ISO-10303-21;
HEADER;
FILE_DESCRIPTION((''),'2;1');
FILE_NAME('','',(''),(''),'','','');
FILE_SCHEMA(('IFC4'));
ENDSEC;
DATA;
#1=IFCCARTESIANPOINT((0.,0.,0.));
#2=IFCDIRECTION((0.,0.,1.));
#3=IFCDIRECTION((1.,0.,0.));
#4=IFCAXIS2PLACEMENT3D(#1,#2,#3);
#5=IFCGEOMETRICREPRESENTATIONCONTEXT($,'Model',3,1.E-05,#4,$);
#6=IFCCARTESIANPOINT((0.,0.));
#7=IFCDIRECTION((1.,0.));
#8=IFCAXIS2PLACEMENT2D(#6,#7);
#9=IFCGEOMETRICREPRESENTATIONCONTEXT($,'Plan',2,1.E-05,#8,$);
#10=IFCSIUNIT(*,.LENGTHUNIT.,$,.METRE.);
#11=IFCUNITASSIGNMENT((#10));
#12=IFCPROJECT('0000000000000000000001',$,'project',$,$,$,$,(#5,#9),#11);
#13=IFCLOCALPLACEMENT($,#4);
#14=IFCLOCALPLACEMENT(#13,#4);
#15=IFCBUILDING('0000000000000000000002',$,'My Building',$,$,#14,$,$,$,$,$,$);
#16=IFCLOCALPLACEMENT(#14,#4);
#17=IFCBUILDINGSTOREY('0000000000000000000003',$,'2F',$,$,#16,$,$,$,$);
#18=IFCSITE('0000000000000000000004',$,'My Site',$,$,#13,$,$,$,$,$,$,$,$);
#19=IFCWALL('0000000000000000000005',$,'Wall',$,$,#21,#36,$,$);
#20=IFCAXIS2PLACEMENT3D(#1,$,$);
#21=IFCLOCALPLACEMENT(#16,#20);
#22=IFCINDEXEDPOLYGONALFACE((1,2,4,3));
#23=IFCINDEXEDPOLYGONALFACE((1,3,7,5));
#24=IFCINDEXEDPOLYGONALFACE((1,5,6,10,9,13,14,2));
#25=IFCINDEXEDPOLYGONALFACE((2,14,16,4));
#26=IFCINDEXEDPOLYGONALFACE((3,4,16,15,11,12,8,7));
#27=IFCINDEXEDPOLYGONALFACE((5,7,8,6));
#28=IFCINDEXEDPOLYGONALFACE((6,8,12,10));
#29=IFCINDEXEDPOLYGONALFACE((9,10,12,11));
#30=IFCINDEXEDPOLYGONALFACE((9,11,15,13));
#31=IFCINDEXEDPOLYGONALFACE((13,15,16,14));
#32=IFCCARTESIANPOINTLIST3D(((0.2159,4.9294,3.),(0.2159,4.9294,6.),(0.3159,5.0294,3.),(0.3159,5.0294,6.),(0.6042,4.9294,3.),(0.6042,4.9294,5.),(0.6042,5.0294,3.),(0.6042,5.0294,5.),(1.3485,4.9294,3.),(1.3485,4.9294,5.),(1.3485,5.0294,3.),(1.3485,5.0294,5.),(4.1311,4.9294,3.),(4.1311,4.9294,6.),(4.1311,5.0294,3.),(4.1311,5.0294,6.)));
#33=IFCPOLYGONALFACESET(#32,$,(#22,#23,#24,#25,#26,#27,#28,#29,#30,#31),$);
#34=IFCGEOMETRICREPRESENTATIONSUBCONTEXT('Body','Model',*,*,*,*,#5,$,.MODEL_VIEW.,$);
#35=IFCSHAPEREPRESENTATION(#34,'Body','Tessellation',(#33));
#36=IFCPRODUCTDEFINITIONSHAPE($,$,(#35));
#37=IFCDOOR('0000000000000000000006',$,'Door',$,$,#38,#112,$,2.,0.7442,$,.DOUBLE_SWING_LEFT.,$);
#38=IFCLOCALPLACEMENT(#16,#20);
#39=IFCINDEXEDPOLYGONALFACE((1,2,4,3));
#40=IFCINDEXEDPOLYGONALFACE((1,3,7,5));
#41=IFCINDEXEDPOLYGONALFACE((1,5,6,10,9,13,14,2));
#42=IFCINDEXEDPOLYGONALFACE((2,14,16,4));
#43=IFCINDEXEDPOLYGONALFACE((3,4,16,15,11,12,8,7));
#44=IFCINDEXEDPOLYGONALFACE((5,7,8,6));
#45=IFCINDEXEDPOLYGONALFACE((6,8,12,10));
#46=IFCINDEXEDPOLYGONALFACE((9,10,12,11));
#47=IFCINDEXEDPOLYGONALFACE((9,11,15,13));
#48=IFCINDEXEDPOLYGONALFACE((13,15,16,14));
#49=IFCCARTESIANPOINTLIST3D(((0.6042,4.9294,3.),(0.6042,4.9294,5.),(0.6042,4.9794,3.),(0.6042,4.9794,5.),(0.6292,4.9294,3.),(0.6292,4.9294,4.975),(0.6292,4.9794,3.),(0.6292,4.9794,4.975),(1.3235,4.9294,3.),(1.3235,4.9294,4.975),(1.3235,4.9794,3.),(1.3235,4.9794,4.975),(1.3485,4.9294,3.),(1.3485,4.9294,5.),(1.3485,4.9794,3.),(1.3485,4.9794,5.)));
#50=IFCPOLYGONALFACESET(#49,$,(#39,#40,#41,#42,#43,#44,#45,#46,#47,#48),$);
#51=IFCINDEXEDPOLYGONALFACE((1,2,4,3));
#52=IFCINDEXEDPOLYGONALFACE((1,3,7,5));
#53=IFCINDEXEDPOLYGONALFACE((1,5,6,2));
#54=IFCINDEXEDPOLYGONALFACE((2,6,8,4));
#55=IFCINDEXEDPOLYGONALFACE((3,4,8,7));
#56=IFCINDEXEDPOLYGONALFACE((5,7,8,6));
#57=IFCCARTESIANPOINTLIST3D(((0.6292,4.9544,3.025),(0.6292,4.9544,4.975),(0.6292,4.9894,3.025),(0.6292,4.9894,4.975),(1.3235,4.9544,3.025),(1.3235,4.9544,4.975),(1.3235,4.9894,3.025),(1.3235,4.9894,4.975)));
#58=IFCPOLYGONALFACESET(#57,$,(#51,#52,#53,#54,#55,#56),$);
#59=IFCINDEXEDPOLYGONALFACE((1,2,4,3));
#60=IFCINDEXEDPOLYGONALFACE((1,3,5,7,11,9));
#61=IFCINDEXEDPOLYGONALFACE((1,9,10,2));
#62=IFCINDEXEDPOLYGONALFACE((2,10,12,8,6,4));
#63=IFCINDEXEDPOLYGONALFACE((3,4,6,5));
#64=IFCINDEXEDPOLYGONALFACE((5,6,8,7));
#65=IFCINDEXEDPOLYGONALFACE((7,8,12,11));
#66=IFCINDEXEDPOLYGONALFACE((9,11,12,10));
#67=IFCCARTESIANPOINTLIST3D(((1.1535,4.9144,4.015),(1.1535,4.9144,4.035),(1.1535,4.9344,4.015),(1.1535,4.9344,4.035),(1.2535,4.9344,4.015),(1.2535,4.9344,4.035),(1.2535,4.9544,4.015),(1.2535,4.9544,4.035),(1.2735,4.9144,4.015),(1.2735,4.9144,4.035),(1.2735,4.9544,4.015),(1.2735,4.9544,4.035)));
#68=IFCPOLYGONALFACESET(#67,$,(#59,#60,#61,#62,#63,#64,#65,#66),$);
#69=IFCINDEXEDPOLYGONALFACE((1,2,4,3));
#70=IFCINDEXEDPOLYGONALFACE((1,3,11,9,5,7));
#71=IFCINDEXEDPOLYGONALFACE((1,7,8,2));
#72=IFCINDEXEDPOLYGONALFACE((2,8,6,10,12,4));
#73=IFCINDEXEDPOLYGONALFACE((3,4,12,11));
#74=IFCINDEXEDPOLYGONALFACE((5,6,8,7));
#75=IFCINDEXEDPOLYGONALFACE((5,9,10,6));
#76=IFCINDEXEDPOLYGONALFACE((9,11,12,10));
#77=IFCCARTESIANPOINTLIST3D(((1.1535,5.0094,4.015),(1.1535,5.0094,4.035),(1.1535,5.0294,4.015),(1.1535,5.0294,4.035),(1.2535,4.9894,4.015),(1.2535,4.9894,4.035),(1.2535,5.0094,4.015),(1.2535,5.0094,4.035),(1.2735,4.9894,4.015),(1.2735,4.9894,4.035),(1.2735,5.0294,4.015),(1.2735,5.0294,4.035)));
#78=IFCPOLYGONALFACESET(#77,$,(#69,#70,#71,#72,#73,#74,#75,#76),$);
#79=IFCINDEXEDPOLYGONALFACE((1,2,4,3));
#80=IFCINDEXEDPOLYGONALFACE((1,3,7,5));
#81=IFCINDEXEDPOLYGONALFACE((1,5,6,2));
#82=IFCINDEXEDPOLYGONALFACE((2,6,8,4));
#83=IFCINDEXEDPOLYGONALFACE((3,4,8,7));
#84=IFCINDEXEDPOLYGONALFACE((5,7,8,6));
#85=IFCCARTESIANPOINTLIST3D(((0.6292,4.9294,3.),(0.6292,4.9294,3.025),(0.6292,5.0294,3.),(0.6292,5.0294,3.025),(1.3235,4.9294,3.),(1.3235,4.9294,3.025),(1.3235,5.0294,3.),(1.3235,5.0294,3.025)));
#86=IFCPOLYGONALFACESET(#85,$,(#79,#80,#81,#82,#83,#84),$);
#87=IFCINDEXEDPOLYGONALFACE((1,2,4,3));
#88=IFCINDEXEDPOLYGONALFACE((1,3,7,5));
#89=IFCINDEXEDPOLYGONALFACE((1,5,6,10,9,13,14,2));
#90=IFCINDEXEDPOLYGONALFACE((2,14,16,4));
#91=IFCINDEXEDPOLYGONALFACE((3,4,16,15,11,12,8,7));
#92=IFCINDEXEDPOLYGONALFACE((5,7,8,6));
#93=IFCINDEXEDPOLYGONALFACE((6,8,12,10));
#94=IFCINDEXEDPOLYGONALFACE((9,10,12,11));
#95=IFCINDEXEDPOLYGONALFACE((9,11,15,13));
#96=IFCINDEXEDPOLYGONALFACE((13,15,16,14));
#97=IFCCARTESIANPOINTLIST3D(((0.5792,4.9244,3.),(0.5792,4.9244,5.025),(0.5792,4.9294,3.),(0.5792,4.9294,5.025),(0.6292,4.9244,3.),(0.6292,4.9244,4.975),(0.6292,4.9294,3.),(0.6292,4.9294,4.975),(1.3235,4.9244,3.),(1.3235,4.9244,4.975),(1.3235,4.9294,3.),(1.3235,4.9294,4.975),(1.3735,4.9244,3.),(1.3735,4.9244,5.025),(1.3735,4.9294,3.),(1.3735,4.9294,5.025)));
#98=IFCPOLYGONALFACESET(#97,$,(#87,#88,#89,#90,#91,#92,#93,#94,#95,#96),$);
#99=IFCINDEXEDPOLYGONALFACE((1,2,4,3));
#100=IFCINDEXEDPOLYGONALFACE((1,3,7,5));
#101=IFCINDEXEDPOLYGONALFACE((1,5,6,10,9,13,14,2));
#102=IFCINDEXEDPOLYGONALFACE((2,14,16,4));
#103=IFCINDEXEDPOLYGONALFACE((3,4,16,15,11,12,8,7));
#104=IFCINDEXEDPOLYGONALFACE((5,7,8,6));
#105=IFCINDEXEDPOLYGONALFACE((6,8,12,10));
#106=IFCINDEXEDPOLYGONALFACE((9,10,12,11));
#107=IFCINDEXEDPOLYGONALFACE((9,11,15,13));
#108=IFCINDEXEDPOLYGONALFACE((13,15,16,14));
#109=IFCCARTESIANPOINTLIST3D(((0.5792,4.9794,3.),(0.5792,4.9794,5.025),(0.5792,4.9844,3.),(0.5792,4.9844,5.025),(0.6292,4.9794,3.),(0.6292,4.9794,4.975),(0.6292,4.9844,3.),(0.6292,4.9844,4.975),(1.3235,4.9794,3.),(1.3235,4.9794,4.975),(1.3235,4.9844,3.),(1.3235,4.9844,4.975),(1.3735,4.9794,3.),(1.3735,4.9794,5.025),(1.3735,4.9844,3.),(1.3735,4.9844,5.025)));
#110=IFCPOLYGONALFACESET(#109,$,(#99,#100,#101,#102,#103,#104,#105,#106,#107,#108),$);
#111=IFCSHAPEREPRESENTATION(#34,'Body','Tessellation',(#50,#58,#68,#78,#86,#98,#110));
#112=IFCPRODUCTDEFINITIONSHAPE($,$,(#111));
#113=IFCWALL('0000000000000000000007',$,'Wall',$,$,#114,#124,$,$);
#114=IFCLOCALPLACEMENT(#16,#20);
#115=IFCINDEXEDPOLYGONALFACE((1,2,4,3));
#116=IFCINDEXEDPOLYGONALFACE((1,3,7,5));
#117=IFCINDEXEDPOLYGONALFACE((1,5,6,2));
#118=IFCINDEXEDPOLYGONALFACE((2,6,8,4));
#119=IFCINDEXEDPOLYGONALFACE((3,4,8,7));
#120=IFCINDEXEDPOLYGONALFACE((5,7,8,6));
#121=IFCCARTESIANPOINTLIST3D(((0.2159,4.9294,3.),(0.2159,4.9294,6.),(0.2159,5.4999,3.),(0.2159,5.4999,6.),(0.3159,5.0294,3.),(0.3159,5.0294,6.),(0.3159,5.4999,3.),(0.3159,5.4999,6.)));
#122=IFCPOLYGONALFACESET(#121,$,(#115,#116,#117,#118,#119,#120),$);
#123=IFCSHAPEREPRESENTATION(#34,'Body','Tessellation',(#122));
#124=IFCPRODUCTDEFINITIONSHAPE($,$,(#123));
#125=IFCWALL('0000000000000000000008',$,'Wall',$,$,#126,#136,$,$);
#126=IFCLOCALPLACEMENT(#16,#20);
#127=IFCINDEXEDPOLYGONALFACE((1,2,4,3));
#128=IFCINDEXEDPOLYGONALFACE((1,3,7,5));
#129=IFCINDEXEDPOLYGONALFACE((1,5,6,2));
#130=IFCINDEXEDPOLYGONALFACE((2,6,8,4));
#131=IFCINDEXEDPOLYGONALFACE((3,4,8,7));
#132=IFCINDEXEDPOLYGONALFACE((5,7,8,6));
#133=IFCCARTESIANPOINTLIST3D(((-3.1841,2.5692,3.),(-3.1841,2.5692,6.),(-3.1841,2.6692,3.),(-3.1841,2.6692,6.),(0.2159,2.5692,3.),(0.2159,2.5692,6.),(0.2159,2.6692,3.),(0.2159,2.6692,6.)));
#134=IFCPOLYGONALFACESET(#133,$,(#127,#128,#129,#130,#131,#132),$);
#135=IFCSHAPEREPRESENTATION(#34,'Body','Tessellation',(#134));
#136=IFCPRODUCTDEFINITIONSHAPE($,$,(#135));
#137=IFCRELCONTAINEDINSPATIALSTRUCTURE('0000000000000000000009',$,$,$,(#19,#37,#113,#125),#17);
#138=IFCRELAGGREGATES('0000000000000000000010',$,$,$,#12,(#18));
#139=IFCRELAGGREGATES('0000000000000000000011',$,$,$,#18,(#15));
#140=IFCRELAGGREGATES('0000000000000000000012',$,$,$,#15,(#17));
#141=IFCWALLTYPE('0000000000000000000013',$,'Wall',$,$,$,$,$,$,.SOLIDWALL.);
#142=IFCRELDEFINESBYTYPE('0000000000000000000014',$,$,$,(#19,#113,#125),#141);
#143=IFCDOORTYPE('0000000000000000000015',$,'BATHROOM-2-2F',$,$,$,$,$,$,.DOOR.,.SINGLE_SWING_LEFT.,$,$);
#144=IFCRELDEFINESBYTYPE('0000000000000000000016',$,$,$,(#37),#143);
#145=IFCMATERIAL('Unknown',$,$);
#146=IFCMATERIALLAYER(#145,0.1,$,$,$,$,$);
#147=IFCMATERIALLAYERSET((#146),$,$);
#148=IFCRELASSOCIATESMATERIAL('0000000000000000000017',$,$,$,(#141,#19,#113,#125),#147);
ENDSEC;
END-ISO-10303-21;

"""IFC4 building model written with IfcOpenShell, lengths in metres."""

from ifc_helpers import new_model, entity, si_unit, frame, origin_with_axes, origin_2d_with_axis, place, context, subcontext, project, spatial, line, indexed_curve, outline, extrude, shape, source, transform, mapped, material, layer, layer_set, layer_usage, type_object, type_shapes, element, fill, save


model = new_model("IFC4")

# Units and contexts
model_context = context("Model", 3, precision=1e-05, world=origin_with_axes())
plan_context = context("Plan", 2, precision=1e-05, world=origin_2d_with_axis())
body_context_1 = subcontext(model_context, "Body", "Model", "MODEL_VIEW")
body_context_2 = subcontext(plan_context, "Body", "Plan", "PLAN_VIEW")
ifc_project = project(units=[si_unit("LENGTHUNIT", "METRE")], contexts=[model_context, plan_context])

# Site, building, storey
site_placement = place(None, origin_with_axes())
site = spatial("IfcSite", under=ifc_project, at=site_placement, Name="My Site")
building_placement = place(site_placement, origin_with_axes())
building = spatial("IfcBuilding", under=site, at=building_placement, Name="My Building")
storey_placement = place(building_placement, origin_with_axes())
storey = spatial("IfcBuildingStorey", under=building, at=storey_placement, Name="2F")

# Shared definitions
ifc_material_1 = material(Name="Unknown")

# Shared definitions
ifc_layer_1 = layer(ifc_material_1, 0.1)
ifc_layer_set_1 = layer_set([ifc_layer_1])
wall_type = type_object("IfcWallType", Name="Wall", PredefinedType="SOLIDWALL", material=ifc_layer_set_1)

# Wall, opening, door
ifc_layer_usage_1 = layer_usage(ifc_layer_set_1, "AXIS2", "POSITIVE", 0.0)
wall_1_placement = place(storey_placement, frame((4.1311, 5.0294, 3.0), z_axis=(0.0, 0.0, 1.0), x_axis=(-1.0, 0.0, 0.0)))
wall_1 = element("IfcWall", 1, at=wall_1_placement, inside=storey, type_object=wall_type, material=ifc_layer_usage_1, Name="Wall", context=body_context_1, shape_type="SweptSolid", body=[
    extrude(outline(indexed_curve([(0.0, 0.0), (0.0, 0.1), (3.9153, 0.1), (3.8153, 0.0)], segments=[line(1, 2, 3, 4, 1)])), origin_with_axes(), (0.0, 0.0, 1.0), 3.0),
])
shared_shape_1 = source(origin_with_axes(), body_context_1, "Body", "SweptSolid", [
    extrude(outline(indexed_curve([(0.0, 0.0), (0.7442, 0.0), (0.7442, 2.0), (0.0, 2.0)], segments=[line(1, 2, 3, 4, 1)])), frame((0.0, -0.6, 0.0), z_axis=(0.0, -1.0, 0.0), x_axis=(1.0, 0.0, 0.0)), (0.0, 0.0, -1.0), 1.2),
])
opening_1_placement = place(wall_1_placement, frame((3.5269, 0.1, 0.0), z_axis=(0.0, 0.0, 1.0), x_axis=(-1.0, 0.0, 0.0)))
opening_1 = element("IfcOpeningElement", 2, at=opening_1_placement, cuts=wall_1, PredefinedType="OPENING", context=body_context_1, shape_type="MappedRepresentation", body=[
    mapped(shared_shape_1, transform((0.0, 0.0, 0.0), x_axis=(1.0, 0.0, 0.0), y_axis=(0.0, 1.0, 0.0), z_axis=(0.0, 0.0, 1.0), scale=1.0)),
])
door_type_1 = type_object("IfcDoorType", Name="BATHROOM-2-2F", OperationType="SINGLE_SWING_LEFT", PredefinedType="DOOR")
shared_shape_2 = source(origin_with_axes(), body_context_1, "Body", "SweptSolid", [
    extrude(outline(indexed_curve([(0.0, 0.0), (0.0, 2.0), (0.7442, 2.0), (0.7442, 0.0), (0.7192, 0.0), (0.7192, 1.975), (0.025, 1.975), (0.025, 0.0)], segments=[line(1, 2, 3, 4, 5, 6, 7, 8, 1)])), frame((0.0, 0.0, 0.0), z_axis=(0.0, -1.0, 0.0), x_axis=(1.0, 0.0, 0.0)), (0.0, 0.0, -1.0), 0.05),
    extrude(outline(indexed_curve([(0.0, 0.0), (0.6942, 0.0), (0.6942, 0.035), (0.0, 0.035)], segments=[line(1, 2, 3, 4, 1)])), frame((0.025, 0.025, 0.025), z_axis=(0.0, 0.0, 1.0), x_axis=(1.0, 0.0, 0.0)), (0.0, 0.0, 1.0), 1.95),
    extrude(outline(indexed_curve([(0.0, 0.0), (0.0, -0.04), (-0.12, -0.04), (-0.12, -0.02), (-0.02, -0.02), (-0.02, 0.0)], segments=[line(1, 2, 3, 4, 5, 6, 1)])), frame((0.6692, 0.025, 1.015), z_axis=(0.0, 0.0, 1.0), x_axis=(1.0, 0.0, 0.0)), (0.0, 0.0, 1.0), 0.02),
    extrude(outline(indexed_curve([(0.0, 0.0), (0.0, 0.04), (-0.12, 0.04), (-0.12, 0.02), (-0.02, 0.02), (-0.02, 0.0)], segments=[line(1, 2, 3, 4, 5, 6, 1)])), frame((0.6692, 0.06, 1.015), z_axis=(0.0, 0.0, 1.0), x_axis=(1.0, 0.0, 0.0)), (0.0, 0.0, 1.0), 0.02),
    extrude(outline(indexed_curve([(0.0, 0.0), (0.6942, 0.0), (0.6942, 0.1), (0.0, 0.1)], segments=[line(1, 2, 3, 4, 1)])), frame((0.025, 0.0, 0.0), z_axis=(0.0, 0.0, 1.0), x_axis=(1.0, 0.0, 0.0)), (0.0, 0.0, 1.0), 0.025),
    extrude(outline(indexed_curve([(0.0, 0.0), (0.0, 2.025), (0.7942, 2.025), (0.7942, 0.0), (0.7442, 0.0), (0.7442, 1.975), (0.05, 1.975), (0.05, 0.0)], segments=[line(1, 2, 3, 4, 5, 6, 7, 8, 1)])), frame((-0.025, -0.005, 0.0), z_axis=(0.0, -1.0, 0.0), x_axis=(1.0, 0.0, 0.0)), (0.0, 0.0, -1.0), 0.005),
    extrude(outline(indexed_curve([(0.0, 0.0), (0.0, 2.025), (0.7942, 2.025), (0.7942, 0.0), (0.7442, 0.0), (0.7442, 1.975), (0.05, 1.975), (0.05, 0.0)], segments=[line(1, 2, 3, 4, 5, 6, 7, 8, 1)])), frame((-0.025, 0.05, 0.0), z_axis=(0.0, -1.0, 0.0), x_axis=(1.0, 0.0, 0.0)), (0.0, 0.0, -1.0), 0.005),
])
shared_shape_3 = source(origin_with_axes(), body_context_2, "Body", "Curve2D", [
    entity("IfcIndexedPolyCurve", entity("IfcCartesianPointList2D", [[0.0, 0.0], [0.025, 0.0], [0.025, 0.05], [0.0, 0.05]]), [entity("IfcLineIndex", [1, 2, 3, 4, 1])]),
    entity("IfcIndexedPolyCurve", entity("IfcCartesianPointList2D", [[0.7442, 0.0], [0.7192, 0.0], [0.7192, 0.05], [0.7442, 0.05]]), [entity("IfcLineIndex", [1, 2, 3, 4, 1])]),
    entity("IfcIndexedPolyCurve", entity("IfcCartesianPointList2D", [[0.025, 0.05], [0.025, -0.6442], [0.06, -0.6442]])),
    entity("IfcTrimmedCurve", entity("IfcEllipse", entity("IfcAxis2Placement2D", entity("IfcCartesianPoint", [0.06, 0.05]), entity("IfcDirection", [1.0, 0.0])), 0.6592, 0.6942), [entity("IfcCartesianPoint", [0.06, -0.6442])], [entity("IfcCartesianPoint", [0.06, 0.7442])], True, "CARTESIAN"),
    entity("IfcIndexedPolyCurve", entity("IfcCartesianPointList2D", [[0.025, 0.05], [0.06, 0.05], [0.06, 0.7442], [0.025, 0.7442]]), [entity("IfcLineIndex", [1, 2, 3, 4, 1])]),
])
type_shapes(door_type_1, [shared_shape_2, shared_shape_3])
door_1_placement = place(opening_1_placement, frame((0.0, 0.0, 0.0), z_axis=(0.0, 0.0, 1.0), x_axis=(1.0, 0.0, 0.0)))
door_1 = element("IfcDoor", 3, at=door_1_placement, inside=storey, type_object=door_type_1, Name="Door", OperationType="DOUBLE_SWING_LEFT", OverallHeight=2.0, OverallWidth=0.7442, shapes=[
    shape(body_context_1, "Body", "MappedRepresentation", [mapped(shared_shape_2, transform((0.0, 0.0, 0.0), x_axis=(1.0, 0.0, 0.0), y_axis=(0.0, 1.0, 0.0), z_axis=(0.0, 0.0, 1.0), scale=1.0))]),
    shape(body_context_2, "Body", "MappedRepresentation", [mapped(shared_shape_3, transform((0.0, 0.0, 0.0), x_axis=(1.0, 0.0, 0.0), y_axis=(0.0, 1.0, 0.0), z_axis=(0.0, 0.0, 1.0), scale=1.0))]),
])
fill(opening_1, door_1)

# Wall
ifc_layer_usage_2 = layer_usage(ifc_layer_set_1, "AXIS2", "POSITIVE", 0.0)
wall_2_placement = place(storey_placement, frame((0.3159, 5.0294, 3.0), z_axis=(0.0, 0.0, 1.0), x_axis=(0.0, 1.0, 0.0)))
element("IfcWall", 4, at=wall_2_placement, inside=storey, type_object=wall_type, material=ifc_layer_usage_2, Name="Wall", context=body_context_1, shape_type="SweptSolid", body=[
    extrude(outline(indexed_curve([(0.0, 0.0), (-0.1, 0.1), (0.4705, 0.1), (0.4705, 0.0)], segments=[line(1, 2, 3, 4, 1)])), origin_with_axes(), (0.0, 0.0, 1.0), 3.0),
])

# Wall
ifc_layer_usage_3 = layer_usage(ifc_layer_set_1, "AXIS2", "POSITIVE", 0.0)
wall_3_placement = place(storey_placement, frame((-3.1841, 2.5692, 3.0), z_axis=(0.0, 0.0, 1.0), x_axis=(1.0, 0.0, 0.0)))
element("IfcWall", 5, at=wall_3_placement, inside=storey, type_object=wall_type, material=ifc_layer_usage_3, Name="Wall", context=body_context_1, shape_type="SweptSolid", body=[
    extrude(outline(indexed_curve([(0.0, 0.0), (0.0, 0.1), (3.4, 0.1), (3.4, 0.0)], segments=[line(1, 2, 3, 4, 1)])), origin_with_axes(), (0.0, 0.0, 1.0), 3.0),
])

save(model, "model.ifc")
